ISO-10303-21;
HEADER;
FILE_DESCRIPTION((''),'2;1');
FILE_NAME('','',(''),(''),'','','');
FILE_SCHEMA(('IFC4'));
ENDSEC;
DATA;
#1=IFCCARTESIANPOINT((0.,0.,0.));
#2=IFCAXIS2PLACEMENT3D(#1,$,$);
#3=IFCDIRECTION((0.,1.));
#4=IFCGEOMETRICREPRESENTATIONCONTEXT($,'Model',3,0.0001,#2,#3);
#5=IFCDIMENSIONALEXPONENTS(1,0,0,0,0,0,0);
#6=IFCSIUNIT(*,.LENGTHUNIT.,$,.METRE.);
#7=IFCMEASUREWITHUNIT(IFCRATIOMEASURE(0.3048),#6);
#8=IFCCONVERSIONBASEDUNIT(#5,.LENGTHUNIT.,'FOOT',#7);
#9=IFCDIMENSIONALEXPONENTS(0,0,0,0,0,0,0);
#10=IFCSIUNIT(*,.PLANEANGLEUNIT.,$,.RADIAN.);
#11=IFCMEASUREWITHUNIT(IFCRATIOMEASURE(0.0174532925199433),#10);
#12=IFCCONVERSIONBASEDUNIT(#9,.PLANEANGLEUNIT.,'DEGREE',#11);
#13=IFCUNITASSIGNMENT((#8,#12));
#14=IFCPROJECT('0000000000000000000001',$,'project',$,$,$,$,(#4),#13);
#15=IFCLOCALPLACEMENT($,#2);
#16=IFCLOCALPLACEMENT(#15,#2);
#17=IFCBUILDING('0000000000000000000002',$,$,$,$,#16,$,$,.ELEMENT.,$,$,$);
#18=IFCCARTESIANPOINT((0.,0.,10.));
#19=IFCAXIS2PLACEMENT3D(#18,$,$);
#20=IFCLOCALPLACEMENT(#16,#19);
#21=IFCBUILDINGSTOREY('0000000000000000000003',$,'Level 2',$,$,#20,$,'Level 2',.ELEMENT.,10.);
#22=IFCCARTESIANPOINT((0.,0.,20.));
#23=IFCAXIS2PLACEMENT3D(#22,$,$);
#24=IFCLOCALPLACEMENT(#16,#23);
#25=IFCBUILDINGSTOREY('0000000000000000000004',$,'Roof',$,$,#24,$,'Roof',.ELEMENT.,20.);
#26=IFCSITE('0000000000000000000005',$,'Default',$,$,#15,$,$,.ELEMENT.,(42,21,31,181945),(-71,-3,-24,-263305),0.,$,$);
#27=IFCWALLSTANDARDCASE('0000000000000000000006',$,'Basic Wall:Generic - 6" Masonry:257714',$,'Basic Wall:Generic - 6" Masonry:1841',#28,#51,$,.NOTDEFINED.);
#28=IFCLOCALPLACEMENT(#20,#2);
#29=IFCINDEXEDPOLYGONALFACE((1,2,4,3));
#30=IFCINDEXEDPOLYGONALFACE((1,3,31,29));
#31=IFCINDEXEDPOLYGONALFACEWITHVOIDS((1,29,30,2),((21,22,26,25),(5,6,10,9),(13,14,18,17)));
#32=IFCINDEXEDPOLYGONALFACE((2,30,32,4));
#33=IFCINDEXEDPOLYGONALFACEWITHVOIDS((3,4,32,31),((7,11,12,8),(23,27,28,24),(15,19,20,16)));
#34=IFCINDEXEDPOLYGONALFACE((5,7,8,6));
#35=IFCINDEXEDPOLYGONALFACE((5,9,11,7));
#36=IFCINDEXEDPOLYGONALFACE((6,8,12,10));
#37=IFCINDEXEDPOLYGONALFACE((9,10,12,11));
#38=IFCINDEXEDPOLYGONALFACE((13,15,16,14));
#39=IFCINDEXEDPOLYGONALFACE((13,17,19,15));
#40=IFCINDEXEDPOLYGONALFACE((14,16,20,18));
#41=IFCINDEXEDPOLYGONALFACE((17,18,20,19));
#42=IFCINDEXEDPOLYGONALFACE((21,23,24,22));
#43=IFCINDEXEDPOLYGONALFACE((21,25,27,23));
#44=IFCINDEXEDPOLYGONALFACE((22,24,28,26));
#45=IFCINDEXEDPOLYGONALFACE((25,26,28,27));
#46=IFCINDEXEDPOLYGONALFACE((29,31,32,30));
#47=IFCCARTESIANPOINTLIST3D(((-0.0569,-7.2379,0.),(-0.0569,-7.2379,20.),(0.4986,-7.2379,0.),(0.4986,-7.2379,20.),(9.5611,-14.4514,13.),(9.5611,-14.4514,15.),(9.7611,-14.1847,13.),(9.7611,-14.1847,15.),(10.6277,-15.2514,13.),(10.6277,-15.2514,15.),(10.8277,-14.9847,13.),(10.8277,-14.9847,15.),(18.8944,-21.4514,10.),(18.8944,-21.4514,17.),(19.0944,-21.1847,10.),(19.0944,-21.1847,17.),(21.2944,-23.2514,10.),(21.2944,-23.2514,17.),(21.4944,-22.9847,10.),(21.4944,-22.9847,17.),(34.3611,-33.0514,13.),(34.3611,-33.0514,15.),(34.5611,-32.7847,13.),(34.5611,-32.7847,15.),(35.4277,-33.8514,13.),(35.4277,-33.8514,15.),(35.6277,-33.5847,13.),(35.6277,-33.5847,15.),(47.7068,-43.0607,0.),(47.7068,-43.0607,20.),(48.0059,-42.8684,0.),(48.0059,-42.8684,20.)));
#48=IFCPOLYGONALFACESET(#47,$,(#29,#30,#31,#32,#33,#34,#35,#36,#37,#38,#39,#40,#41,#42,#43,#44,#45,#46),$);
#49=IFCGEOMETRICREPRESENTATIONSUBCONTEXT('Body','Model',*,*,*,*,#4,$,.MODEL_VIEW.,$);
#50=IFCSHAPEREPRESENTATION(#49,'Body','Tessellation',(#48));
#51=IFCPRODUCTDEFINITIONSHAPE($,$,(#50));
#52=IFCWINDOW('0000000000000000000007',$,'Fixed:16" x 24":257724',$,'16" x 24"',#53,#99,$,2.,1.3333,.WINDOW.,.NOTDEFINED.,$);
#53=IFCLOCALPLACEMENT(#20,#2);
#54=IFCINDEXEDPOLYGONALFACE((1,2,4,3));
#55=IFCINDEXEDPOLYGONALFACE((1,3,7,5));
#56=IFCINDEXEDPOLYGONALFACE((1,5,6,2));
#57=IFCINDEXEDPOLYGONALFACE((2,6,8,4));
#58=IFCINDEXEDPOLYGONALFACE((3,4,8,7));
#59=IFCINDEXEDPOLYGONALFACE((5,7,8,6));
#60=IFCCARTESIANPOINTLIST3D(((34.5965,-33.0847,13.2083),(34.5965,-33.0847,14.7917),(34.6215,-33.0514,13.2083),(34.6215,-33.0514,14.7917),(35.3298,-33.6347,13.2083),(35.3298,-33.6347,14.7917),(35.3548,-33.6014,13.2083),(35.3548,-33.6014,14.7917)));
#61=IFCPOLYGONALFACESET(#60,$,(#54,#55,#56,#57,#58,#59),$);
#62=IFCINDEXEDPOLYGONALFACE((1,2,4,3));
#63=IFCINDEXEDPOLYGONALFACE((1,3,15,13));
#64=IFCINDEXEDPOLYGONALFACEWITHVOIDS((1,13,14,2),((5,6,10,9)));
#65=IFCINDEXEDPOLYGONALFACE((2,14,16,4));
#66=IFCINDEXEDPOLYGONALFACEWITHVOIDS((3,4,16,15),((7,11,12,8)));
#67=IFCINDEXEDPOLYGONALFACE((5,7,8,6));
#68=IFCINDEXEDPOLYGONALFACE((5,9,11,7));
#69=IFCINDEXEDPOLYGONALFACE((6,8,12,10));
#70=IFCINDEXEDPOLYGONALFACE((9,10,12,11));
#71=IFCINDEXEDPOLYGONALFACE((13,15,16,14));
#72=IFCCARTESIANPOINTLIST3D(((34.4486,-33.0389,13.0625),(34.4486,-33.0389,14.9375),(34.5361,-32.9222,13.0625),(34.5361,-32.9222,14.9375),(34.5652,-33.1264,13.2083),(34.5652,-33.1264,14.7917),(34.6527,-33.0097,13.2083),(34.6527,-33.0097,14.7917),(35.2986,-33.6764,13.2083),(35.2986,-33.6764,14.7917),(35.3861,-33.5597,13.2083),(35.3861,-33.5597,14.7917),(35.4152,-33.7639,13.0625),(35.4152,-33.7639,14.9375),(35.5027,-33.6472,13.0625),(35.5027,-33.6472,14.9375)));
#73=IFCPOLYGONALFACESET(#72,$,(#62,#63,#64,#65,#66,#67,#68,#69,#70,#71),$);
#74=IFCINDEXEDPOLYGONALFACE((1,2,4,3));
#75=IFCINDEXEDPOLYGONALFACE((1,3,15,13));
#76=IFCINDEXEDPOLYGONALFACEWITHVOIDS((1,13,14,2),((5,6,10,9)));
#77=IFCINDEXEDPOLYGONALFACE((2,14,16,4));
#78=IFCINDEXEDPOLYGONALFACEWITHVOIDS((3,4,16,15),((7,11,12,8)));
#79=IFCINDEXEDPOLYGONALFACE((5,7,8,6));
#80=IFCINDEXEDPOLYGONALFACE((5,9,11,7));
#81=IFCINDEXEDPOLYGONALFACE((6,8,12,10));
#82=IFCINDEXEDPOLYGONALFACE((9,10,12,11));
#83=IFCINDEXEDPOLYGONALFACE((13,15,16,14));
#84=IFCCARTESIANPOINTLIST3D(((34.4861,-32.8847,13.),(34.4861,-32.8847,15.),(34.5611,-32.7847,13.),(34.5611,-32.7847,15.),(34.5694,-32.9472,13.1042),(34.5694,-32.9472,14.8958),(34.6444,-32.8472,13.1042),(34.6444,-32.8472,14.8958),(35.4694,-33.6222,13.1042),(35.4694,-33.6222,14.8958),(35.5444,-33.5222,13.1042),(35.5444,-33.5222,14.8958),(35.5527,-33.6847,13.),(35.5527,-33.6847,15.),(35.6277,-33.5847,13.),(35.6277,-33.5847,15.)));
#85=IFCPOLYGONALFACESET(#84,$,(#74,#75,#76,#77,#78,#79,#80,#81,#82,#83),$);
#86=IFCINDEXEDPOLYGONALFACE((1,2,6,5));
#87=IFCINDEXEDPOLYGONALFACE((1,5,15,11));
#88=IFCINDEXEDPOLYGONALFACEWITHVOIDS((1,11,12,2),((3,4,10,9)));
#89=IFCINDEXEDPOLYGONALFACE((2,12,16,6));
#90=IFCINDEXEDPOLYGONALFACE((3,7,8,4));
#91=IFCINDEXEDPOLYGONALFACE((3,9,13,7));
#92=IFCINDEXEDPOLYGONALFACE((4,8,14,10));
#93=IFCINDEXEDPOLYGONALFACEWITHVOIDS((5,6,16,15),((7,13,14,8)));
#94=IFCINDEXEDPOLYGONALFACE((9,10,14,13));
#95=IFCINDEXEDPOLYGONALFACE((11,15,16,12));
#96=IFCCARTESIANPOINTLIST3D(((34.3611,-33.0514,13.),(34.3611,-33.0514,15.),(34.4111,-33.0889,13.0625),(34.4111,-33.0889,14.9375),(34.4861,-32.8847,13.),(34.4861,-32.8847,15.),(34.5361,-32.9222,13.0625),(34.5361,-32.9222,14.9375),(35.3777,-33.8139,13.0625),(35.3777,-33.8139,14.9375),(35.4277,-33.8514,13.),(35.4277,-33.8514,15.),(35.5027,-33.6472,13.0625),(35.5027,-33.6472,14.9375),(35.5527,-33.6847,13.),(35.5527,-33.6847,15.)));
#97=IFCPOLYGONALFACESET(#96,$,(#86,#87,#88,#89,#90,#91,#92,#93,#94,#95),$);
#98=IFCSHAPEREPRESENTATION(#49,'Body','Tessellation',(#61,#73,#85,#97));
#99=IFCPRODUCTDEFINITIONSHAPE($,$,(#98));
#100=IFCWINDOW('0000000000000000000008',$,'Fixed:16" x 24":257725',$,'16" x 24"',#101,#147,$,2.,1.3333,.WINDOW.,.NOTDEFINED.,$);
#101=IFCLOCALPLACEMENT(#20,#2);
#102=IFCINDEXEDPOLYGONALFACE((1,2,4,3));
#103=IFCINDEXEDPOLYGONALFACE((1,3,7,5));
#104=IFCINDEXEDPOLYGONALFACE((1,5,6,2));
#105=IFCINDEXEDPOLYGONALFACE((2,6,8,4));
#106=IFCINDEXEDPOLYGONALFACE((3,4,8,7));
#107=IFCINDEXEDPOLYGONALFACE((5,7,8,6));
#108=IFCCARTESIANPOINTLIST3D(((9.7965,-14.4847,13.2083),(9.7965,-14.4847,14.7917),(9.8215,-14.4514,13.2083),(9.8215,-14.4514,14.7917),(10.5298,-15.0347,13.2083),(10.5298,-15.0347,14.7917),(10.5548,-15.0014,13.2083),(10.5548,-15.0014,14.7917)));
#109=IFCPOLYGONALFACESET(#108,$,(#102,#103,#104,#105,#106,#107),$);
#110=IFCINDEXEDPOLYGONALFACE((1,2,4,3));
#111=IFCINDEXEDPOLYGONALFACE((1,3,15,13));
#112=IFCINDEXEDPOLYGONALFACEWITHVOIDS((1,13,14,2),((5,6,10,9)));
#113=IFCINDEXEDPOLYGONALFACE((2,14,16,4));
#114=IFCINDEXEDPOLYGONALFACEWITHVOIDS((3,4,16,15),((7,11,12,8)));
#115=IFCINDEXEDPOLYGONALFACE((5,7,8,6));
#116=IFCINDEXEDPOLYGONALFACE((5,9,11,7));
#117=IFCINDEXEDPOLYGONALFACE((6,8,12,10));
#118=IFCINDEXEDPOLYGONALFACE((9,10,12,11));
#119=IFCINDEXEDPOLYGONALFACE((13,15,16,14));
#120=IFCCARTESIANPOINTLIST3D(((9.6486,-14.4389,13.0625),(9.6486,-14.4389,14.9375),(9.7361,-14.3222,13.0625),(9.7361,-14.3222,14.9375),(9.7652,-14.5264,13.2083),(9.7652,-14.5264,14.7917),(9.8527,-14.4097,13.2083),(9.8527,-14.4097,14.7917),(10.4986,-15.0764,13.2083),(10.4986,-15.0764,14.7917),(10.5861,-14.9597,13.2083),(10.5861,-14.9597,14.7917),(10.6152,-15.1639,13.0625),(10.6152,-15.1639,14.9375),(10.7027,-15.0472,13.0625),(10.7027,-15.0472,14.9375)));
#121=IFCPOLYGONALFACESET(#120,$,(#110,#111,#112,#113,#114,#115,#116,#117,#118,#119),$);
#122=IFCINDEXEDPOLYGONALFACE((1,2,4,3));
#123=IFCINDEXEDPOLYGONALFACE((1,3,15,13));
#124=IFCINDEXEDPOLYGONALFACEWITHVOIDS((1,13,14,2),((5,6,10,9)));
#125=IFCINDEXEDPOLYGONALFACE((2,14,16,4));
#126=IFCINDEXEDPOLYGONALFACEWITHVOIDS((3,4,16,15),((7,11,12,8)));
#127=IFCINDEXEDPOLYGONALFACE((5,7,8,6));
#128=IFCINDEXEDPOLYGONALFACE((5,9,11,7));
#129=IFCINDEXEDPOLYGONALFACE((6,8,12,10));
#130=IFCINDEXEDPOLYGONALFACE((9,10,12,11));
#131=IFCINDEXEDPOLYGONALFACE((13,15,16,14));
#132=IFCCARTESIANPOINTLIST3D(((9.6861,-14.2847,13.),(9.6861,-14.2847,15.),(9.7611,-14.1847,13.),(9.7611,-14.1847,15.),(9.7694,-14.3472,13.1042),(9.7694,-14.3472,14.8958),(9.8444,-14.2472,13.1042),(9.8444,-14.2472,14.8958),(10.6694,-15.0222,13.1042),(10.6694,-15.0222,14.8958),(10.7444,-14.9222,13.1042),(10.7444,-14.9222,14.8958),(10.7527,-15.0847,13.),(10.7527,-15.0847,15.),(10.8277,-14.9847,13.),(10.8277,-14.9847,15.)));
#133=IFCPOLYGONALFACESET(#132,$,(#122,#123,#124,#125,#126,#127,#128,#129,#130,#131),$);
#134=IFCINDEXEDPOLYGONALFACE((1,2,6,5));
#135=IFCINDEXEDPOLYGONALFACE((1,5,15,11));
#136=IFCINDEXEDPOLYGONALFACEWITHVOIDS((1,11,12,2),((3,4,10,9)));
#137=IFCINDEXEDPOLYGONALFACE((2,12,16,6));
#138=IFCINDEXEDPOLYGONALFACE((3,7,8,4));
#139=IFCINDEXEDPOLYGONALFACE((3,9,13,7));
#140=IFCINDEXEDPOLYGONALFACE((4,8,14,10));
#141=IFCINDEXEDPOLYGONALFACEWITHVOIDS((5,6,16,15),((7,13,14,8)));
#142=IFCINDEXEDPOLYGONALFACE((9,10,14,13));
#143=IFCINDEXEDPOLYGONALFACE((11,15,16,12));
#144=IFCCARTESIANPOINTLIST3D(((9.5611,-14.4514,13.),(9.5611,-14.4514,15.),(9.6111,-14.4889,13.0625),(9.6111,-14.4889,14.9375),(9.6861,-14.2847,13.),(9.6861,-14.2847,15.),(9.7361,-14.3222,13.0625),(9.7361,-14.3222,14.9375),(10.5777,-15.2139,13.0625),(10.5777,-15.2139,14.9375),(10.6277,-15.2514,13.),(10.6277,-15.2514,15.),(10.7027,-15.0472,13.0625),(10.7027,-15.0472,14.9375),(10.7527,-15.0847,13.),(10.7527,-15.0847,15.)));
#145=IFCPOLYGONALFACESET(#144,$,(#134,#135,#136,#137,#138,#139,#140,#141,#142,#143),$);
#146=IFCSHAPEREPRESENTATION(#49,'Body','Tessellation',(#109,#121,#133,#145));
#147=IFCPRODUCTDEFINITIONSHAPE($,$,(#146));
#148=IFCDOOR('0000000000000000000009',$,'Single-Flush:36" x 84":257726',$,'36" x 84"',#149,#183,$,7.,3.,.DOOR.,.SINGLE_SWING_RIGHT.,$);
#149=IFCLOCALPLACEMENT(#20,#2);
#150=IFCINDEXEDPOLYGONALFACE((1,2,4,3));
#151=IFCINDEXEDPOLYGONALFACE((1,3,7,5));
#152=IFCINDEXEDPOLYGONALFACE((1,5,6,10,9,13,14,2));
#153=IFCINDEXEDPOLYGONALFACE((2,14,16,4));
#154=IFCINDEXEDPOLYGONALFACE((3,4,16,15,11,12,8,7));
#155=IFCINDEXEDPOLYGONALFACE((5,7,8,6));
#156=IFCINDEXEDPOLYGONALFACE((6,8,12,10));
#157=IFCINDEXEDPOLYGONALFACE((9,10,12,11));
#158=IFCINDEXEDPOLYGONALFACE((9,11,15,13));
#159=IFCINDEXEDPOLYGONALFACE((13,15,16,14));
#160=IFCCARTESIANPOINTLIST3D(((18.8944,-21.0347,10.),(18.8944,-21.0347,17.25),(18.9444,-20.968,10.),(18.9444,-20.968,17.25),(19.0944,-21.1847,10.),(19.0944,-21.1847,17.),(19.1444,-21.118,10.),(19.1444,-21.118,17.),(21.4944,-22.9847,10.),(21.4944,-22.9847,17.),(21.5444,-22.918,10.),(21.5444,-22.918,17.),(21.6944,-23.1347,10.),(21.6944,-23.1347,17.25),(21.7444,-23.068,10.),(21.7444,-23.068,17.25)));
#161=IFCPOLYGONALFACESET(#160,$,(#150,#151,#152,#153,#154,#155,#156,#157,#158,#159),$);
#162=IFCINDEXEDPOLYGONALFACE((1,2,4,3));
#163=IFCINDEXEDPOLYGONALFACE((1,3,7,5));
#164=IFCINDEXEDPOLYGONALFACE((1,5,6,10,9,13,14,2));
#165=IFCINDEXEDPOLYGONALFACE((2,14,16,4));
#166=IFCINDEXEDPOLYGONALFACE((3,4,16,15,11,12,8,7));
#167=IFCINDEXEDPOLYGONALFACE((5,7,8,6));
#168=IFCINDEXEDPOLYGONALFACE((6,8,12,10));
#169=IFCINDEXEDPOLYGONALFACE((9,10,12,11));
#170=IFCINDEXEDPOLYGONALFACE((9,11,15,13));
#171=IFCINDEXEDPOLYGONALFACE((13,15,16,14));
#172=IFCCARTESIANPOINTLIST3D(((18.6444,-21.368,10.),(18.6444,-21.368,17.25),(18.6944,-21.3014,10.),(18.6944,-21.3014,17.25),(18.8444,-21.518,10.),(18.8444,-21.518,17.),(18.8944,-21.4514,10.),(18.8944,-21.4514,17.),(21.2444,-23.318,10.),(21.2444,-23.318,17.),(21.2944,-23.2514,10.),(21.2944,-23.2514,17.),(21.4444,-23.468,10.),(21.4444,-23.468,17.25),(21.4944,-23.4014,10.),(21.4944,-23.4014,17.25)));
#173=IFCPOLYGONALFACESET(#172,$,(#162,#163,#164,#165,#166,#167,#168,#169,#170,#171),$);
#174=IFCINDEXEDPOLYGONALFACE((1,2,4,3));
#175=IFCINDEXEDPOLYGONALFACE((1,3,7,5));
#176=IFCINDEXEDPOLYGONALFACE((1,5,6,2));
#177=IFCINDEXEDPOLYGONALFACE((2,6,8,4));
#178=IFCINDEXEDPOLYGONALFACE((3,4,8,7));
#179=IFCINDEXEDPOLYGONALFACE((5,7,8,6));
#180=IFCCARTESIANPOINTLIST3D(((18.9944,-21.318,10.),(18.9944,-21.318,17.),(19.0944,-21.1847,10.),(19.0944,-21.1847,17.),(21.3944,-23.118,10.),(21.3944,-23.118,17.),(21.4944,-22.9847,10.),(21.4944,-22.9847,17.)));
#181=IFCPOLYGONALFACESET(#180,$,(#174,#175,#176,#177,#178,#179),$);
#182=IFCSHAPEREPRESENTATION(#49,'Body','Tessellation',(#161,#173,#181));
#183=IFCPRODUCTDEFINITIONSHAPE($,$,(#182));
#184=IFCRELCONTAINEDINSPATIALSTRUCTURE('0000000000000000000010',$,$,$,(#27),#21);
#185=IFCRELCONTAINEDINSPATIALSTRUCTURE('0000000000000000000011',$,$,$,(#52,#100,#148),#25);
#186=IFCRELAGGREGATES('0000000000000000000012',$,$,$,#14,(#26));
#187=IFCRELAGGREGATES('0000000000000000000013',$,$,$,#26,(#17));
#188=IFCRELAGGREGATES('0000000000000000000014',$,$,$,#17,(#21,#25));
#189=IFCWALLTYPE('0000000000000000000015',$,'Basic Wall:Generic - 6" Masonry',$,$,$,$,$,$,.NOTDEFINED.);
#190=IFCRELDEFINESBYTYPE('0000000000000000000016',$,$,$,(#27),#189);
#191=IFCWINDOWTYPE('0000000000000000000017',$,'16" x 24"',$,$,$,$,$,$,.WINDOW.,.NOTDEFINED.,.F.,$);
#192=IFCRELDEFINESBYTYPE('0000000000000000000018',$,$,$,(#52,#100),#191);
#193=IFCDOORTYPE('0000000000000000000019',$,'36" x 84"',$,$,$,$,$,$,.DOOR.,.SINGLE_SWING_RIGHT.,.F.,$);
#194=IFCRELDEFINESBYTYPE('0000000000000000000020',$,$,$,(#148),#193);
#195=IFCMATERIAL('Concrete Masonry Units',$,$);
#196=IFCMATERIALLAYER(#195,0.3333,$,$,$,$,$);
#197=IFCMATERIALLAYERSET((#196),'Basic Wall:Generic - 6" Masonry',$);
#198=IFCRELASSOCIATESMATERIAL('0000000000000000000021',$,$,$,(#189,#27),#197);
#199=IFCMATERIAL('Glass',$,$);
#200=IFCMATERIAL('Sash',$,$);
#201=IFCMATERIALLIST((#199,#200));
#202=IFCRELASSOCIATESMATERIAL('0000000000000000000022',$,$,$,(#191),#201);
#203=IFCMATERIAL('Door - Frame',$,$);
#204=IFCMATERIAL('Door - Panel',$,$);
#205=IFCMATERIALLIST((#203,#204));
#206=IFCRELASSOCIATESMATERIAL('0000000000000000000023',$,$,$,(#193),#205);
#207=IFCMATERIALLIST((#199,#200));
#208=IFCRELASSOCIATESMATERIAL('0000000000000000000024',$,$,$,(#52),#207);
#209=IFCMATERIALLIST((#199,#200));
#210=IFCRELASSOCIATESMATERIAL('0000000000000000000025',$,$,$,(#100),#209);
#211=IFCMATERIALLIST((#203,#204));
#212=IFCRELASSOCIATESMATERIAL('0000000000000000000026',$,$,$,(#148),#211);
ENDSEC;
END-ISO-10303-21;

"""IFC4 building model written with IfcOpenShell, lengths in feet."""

from ifc_helpers import new_model, entity, si_unit, converted_unit, direction, frame, frame_2d, origin, origin_2d_with_axis, place, context, subcontext, project, spatial, polyline, rectangle, outline, extrude, source, transform, mapped, material, material_list, layer, layer_set, layer_usage, type_object, type_shapes, element, fill, save


model = new_model("IFC4")

# Units and contexts
model_context = context("Model", 3, precision=0.0001, world=origin(), true_north=direction((0.0, 1.0)))
body_context = subcontext(model_context, "Body", "Model", "MODEL_VIEW")
ifc_project = project(units=[converted_unit("LENGTHUNIT", "FOOT", entity("IfcRatioMeasure", 0.3048), si_unit("LENGTHUNIT", "METRE"), dimensions=[1, 0, 0, 0, 0, 0, 0]), converted_unit("PLANEANGLEUNIT", "DEGREE", entity("IfcRatioMeasure", 0.0174532925199433), si_unit("PLANEANGLEUNIT", "RADIAN"), dimensions=[0, 0, 0, 0, 0, 0, 0])], contexts=[model_context])

# Site, building, storey
site_placement = place(None, origin())
site = spatial("IfcSite", under=ifc_project, at=site_placement, Name="Default", CompositionType="ELEMENT", RefLatitude=(42, 21, 31, 181945), RefLongitude=(-71, -3, -24, -263305), RefElevation=0.0)
building_placement = place(site_placement, origin())
building = spatial("IfcBuilding", under=site, at=building_placement, CompositionType="ELEMENT")
storey_1_placement = place(building_placement, frame((0.0, 0.0, 10.0)))
storey_1 = spatial("IfcBuildingStorey", under=building, at=storey_1_placement, Name="Level 2", LongName="Level 2", CompositionType="ELEMENT", Elevation=10.0)

# Shared definitions
ifc_material_1 = material(Name="Concrete Masonry Units")
ifc_layer = layer(ifc_material_1, 0.3333)
ifc_layer_set = layer_set([ifc_layer], Name="Basic Wall:Generic - 6\" Masonry")
wall_type = type_object("IfcWallType", Name="Basic Wall:Generic - 6\" Masonry", PredefinedType="NOTDEFINED", material=ifc_layer_set)

# Shared definitions
storey_2_placement = place(building_placement, frame((0.0, 0.0, 20.0)))
storey_2 = spatial("IfcBuildingStorey", under=building, at=storey_2_placement, Name="Roof", LongName="Roof", CompositionType="ELEMENT", Elevation=20.0)

# Shared definitions
ifc_material_2 = material(Name="Glass")
ifc_material_3 = material(Name="Sash")
ifc_material_list_1 = material_list([ifc_material_2, ifc_material_3])
window_type = type_object("IfcWindowType", Name="16\" x 24\"", ParameterTakesPrecedence=False, PartitioningType="NOTDEFINED", PredefinedType="WINDOW", material=ifc_material_list_1)
shared_shape_1 = source(origin(), body_context, "Body", "SweptSolid", [
    extrude(rectangle(XDim=0.0417, YDim=0.9167, at=origin_2d_with_axis()), frame((0.6667, 0.1979, 0.2083), z_axis=(0.0, 0.0, 1.0), x_axis=(0.0, 1.0, 0.0)), (0.0, 0.0, 1.0), 1.5833),
    extrude(outline(polyline([(-0.6042, -0.9375), (0.6042, -0.9375), (0.6042, 0.9375), (-0.6042, 0.9375), (-0.6042, -0.9375)]), holes=[polyline([(-0.4583, -0.7917), (-0.4583, 0.7917), (0.4583, 0.7917), (0.4583, -0.7917), (-0.4583, -0.7917)])]), frame((0.6667, 0.125, 1.0), z_axis=(0.0, 1.0, 0.0), x_axis=(1.0, 0.0, 0.0)), (0.0, 0.0, 1.0), 0.1458),
    extrude(outline(polyline([(-0.6667, -1.0), (0.6667, -1.0), (0.6667, 1.0), (-0.6667, 1.0), (-0.6667, -1.0)]), holes=[polyline([(-0.5625, -0.8958), (-0.5625, 0.8958), (0.5625, 0.8958), (0.5625, -0.8958), (-0.5625, -0.8958)])]), frame((0.6667, 0.0, 1.0), z_axis=(0.0, 1.0, 0.0), x_axis=(1.0, 0.0, 0.0)), (0.0, 0.0, 1.0), 0.125),
    extrude(outline(polyline([(-1.0, -0.6667), (1.0, -0.6667), (1.0, 0.6667), (-1.0, 0.6667), (-1.0, -0.6667)]), holes=[polyline([(-0.9375, -0.6042), (-0.9375, 0.6042), (0.9375, 0.6042), (0.9375, -0.6042), (-0.9375, -0.6042)])]), frame((0.6667, 0.125, 1.0), z_axis=(0.0, 1.0, 0.0), x_axis=(0.0, 0.0, -1.0)), (0.0, 0.0, 1.0), 0.2083),
])
type_shapes(window_type, [shared_shape_1])

# Shared definitions
ifc_material_4 = material(Name="Door - Frame")
ifc_material_5 = material(Name="Door - Panel")
ifc_material_list_2 = material_list([ifc_material_4, ifc_material_5])
door_type = type_object("IfcDoorType", Name="36\" x 84\"", OperationType="SINGLE_SWING_RIGHT", ParameterTakesPrecedence=False, PredefinedType="DOOR", material=ifc_material_list_2)
shared_shape_2 = source(origin(), body_context, "Body", "SweptSolid", [
    extrude(outline(polyline([(-1.75, -3.6875), (1.75, -3.6875), (1.75, 3.5625), (1.5, 3.5625), (1.5, -3.4375), (-1.5, -3.4375), (-1.5, 3.5625), (-1.75, 3.5625), (-1.75, -3.6875)])), frame((1.5, 0.3333, 3.5625), z_axis=(0.0, 1.0, 0.0), x_axis=(1.0, 0.0, 0.0)), (0.0, 0.0, 1.0), 0.0833),
    extrude(outline(polyline([(-3.6875, -1.75), (3.5625, -1.75), (3.5625, -1.5), (-3.4375, -1.5), (-3.4375, 1.5), (3.5625, 1.5), (3.5625, 1.75), (-3.6875, 1.75), (-3.6875, -1.75)])), frame((1.5, -0.0833, 3.5625), z_axis=(0.0, 1.0, 0.0), x_axis=(0.0, 0.0, -1.0)), (0.0, 0.0, 1.0), 0.0833),
    extrude(rectangle(XDim=0.1667, YDim=3.0, at=frame_2d((0.0, 0.0), x_axis=(1.0, 0.0))), frame((1.5, 0.25, 0.0), z_axis=(0.0, 0.0, 1.0), x_axis=(0.0, 1.0, 0.0)), (0.0, 0.0, 1.0), 7.0),
])
type_shapes(door_type, [shared_shape_2])

# Wall, openings, windows, door
ifc_layer_usage_1 = layer_usage(ifc_layer_set, "AXIS2", "NEGATIVE", 0.1667)
wall_1_placement = place(storey_1_placement, frame((47.9059, -43.0017, 0.0), z_axis=(0.0, 0.0, 1.0), x_axis=(-0.8, 0.6, 0.0)))
wall_1 = element("IfcWallStandardCase", 1, at=wall_1_placement, inside=storey_1, type_object=wall_type, material=ifc_layer_usage_1, Name="Basic Wall:Generic - 6\" Masonry:257714", ObjectType="Basic Wall:Generic - 6\" Masonry:1841", PredefinedType="NOTDEFINED", context=body_context, shape_type="SweptSolid", body=[
    extrude(outline(polyline([(59.3842, -0.1667), (59.8286, 0.1667), (0.1239, 0.1667), (0.0, -0.1667), (59.3842, -0.1667)])), origin(), (0.0, 0.0, 1.0), 20.0),
])
opening_1_placement = place(wall_1_placement, frame((36.1394, 0.1667, 10.0)))
opening_1 = element("IfcOpeningElement", 2, at=opening_1_placement, cuts=wall_1, ObjectType="Opening", PredefinedType="OPENING", context=body_context, shape_type="SweptSolid", body=[
    extrude(rectangle(XDim=3.0, YDim=7.0, at=frame_2d((3.5, 1.5), x_axis=(0.0, 1.0))), frame((0.0, 0.0, 0.0), z_axis=(0.0, -1.0, 0.0), x_axis=(0.0, 0.0, 1.0)), (0.0, 0.0, 1.0), 0.3333),
])
opening_2_placement = place(wall_1_placement, frame((15.4728, -0.1667, 13.0)))
opening_2 = element("IfcOpeningElement", 3, at=opening_2_placement, cuts=wall_1, ObjectType="Opening", PredefinedType="OPENING", context=body_context, shape_type="SweptSolid", body=[
    extrude(rectangle(XDim=2.0, YDim=1.3333, at=frame_2d((1.0, 0.6667), x_axis=(-1.0, 0.0))), frame((0.0, 0.0, 0.0), z_axis=(0.0, 1.0, 0.0), x_axis=(0.0, 0.0, 1.0)), (0.0, 0.0, 1.0), 0.3333),
])
opening_3_placement = place(wall_1_placement, frame((46.4728, -0.1667, 13.0)))
opening_3 = element("IfcOpeningElement", 4, at=opening_3_placement, cuts=wall_1, ObjectType="Opening", PredefinedType="OPENING", context=body_context, shape_type="SweptSolid", body=[
    extrude(rectangle(XDim=2.0, YDim=1.3333, at=frame_2d((1.0, 0.6667), x_axis=(-1.0, 0.0))), frame((0.0, 0.0, 0.0), z_axis=(0.0, 1.0, 0.0), x_axis=(0.0, 0.0, 1.0)), (0.0, 0.0, 1.0), 0.3333),
])
ifc_material_list_3 = material_list([ifc_material_2, ifc_material_3])
window_1_placement = place(opening_2_placement, origin())
window_1 = element("IfcWindow", 5, at=window_1_placement, inside=storey_2, type_object=window_type, material=ifc_material_list_3, Name="Fixed:16\" x 24\":257724", ObjectType="16\" x 24\"", OverallHeight=2.0, OverallWidth=1.3333, PartitioningType="NOTDEFINED", PredefinedType="WINDOW", context=body_context, shape_type="MappedRepresentation", body=[
    mapped(shared_shape_1, transform((0.0, 0.0, 0.0), scale=1.0)),
])
fill(opening_2, window_1)
ifc_material_list_4 = material_list([ifc_material_2, ifc_material_3])
window_2_placement = place(opening_3_placement, origin())
window_2 = element("IfcWindow", 6, at=window_2_placement, inside=storey_2, type_object=window_type, material=ifc_material_list_4, Name="Fixed:16\" x 24\":257725", ObjectType="16\" x 24\"", OverallHeight=2.0, OverallWidth=1.3333, PartitioningType="NOTDEFINED", PredefinedType="WINDOW", context=body_context, shape_type="MappedRepresentation", body=[
    mapped(shared_shape_1, transform((0.0, 0.0, 0.0), scale=1.0)),
])
fill(opening_3, window_2)
ifc_material_list_5 = material_list([ifc_material_4, ifc_material_5])
door_1_placement = place(opening_1_placement, frame((0.0, 0.0, 0.0), z_axis=(0.0, 0.0, 1.0), x_axis=(-1.0, 0.0, 0.0)))
door_1 = element("IfcDoor", 7, at=door_1_placement, inside=storey_2, type_object=door_type, material=ifc_material_list_5, Name="Single-Flush:36\" x 84\":257726", ObjectType="36\" x 84\"", OperationType="SINGLE_SWING_RIGHT", OverallHeight=7.0, OverallWidth=3.0, PredefinedType="DOOR", context=body_context, shape_type="MappedRepresentation", body=[
    mapped(shared_shape_2, transform((0.0, 0.0, 0.0), scale=1.0)),
])
fill(opening_1, door_1)

save(model, "model.ifc")
